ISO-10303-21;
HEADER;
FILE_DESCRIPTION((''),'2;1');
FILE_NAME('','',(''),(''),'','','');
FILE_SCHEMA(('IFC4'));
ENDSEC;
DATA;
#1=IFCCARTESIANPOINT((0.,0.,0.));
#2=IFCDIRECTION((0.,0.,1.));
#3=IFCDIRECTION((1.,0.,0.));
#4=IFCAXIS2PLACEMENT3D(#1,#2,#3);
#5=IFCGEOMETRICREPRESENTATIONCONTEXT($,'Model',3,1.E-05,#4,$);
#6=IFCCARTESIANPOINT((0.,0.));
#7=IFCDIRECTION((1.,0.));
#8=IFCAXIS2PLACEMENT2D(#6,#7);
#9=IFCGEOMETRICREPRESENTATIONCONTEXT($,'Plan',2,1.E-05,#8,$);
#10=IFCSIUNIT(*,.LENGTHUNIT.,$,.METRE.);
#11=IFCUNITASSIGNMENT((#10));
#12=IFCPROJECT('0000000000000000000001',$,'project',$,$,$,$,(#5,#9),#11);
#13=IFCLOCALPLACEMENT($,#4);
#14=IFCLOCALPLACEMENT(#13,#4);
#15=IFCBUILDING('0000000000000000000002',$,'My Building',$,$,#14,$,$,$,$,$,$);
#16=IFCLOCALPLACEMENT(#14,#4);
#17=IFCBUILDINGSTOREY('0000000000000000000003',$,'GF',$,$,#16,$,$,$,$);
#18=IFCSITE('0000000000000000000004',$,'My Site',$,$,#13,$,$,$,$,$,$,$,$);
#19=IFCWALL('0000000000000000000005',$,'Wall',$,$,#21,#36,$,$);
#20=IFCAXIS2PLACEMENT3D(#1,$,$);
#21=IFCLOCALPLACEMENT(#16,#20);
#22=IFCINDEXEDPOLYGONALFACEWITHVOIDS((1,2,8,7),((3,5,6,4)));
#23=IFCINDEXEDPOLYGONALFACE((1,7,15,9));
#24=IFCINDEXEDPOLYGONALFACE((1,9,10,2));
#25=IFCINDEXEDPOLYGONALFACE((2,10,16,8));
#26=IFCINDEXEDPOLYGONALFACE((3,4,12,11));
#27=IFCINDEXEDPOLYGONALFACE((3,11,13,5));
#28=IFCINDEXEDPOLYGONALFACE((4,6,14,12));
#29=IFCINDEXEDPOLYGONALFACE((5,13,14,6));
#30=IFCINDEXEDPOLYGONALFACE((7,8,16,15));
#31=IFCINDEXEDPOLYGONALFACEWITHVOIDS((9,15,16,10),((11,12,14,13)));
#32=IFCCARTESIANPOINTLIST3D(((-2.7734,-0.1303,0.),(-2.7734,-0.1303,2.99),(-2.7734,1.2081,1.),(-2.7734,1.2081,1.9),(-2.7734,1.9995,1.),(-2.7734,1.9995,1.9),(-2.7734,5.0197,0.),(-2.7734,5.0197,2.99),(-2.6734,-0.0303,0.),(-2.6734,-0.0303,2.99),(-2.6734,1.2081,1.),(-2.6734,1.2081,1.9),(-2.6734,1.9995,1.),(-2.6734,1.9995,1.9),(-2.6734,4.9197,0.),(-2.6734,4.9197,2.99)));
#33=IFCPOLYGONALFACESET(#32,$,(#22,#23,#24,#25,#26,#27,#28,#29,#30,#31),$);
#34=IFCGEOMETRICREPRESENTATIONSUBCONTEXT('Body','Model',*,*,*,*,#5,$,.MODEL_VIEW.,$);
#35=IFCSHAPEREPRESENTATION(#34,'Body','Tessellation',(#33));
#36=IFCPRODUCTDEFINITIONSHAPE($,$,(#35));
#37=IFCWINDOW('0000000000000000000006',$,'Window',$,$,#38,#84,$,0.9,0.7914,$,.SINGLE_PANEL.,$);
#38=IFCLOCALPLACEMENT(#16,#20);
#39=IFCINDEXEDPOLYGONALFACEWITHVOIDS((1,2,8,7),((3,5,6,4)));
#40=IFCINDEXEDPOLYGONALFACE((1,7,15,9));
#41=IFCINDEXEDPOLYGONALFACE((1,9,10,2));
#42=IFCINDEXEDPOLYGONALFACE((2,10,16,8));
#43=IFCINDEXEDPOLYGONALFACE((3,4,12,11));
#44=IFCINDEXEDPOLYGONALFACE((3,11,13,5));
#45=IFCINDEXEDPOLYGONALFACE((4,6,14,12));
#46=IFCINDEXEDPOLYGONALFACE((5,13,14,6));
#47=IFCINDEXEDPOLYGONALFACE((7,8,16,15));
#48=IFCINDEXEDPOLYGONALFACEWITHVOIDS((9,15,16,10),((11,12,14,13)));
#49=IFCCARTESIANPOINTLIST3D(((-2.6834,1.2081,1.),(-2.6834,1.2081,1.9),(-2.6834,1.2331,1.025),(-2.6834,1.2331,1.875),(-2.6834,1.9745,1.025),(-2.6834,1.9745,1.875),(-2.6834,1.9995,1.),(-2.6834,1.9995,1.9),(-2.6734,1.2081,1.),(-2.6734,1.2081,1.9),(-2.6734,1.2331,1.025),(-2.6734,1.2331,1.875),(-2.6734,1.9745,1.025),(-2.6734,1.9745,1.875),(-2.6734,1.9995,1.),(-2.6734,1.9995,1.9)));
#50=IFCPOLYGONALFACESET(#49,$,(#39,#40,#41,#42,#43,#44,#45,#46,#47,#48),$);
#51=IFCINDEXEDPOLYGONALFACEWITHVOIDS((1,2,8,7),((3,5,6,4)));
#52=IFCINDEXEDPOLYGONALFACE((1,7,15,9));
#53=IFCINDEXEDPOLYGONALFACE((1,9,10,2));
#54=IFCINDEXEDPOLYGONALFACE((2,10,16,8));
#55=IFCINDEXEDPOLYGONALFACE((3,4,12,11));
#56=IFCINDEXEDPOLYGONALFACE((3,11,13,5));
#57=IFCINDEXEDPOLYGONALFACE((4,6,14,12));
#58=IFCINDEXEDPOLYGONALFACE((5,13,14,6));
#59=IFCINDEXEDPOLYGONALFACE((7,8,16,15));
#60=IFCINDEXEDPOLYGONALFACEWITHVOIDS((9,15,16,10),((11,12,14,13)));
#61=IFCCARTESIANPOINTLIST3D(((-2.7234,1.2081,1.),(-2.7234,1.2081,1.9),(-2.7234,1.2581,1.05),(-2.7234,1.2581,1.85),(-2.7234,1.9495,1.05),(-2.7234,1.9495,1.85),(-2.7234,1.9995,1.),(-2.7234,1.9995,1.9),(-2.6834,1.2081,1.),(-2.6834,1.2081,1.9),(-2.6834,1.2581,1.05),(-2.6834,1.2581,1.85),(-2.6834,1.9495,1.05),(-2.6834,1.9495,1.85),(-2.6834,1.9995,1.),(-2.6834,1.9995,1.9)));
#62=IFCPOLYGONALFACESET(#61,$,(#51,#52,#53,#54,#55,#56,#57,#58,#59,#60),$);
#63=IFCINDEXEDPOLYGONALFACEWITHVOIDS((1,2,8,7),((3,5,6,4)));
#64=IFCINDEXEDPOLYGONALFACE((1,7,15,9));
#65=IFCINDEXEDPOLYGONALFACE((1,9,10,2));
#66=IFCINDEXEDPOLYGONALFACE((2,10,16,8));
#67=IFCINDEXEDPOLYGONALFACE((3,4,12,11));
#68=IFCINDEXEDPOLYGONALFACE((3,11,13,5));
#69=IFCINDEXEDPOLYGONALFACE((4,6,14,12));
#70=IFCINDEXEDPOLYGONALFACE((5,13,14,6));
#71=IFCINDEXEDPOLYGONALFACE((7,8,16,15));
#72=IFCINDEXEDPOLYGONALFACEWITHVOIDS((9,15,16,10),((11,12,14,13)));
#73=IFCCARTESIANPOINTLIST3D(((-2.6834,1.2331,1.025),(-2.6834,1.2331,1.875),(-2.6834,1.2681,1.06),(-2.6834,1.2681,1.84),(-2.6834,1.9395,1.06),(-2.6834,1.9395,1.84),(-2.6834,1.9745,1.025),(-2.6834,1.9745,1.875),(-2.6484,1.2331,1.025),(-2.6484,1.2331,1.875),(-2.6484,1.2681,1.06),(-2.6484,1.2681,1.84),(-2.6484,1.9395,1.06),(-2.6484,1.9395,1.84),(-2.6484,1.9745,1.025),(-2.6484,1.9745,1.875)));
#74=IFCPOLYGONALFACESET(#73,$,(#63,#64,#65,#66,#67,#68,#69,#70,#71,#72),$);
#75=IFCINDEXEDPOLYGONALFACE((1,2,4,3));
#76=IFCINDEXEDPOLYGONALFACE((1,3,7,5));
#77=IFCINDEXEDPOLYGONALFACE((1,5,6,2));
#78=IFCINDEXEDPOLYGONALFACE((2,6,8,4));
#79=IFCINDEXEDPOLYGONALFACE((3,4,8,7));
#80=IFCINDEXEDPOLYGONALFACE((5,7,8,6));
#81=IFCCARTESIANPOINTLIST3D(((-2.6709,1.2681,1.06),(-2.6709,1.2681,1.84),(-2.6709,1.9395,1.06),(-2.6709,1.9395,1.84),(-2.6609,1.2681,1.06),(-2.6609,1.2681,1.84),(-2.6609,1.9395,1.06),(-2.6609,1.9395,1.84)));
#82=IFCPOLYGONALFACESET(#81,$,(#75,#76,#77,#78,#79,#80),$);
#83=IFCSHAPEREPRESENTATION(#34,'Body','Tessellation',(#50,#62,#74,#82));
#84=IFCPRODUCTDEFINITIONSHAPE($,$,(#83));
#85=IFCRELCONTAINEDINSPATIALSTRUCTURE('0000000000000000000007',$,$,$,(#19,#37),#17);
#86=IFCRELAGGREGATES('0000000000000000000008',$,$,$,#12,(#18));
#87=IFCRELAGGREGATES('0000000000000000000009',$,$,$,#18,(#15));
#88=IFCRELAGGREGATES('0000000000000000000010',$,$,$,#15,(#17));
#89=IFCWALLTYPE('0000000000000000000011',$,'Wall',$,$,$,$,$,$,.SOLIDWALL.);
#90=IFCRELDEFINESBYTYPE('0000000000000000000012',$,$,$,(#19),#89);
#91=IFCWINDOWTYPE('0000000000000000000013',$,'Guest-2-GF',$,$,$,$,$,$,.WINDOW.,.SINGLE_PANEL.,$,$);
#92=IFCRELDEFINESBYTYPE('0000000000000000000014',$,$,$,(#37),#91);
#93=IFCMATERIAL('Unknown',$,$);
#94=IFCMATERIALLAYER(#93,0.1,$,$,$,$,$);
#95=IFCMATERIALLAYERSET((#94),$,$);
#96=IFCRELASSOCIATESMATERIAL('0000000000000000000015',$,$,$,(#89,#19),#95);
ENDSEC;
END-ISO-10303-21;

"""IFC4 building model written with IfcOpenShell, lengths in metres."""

from ifc_helpers import new_model, entity, si_unit, frame, origin_with_axes, origin_2d_with_axis, place, context, subcontext, project, spatial, line, indexed_curve, outline, extrude, shape, source, transform, mapped, material, layer, layer_set, layer_usage, type_object, type_shapes, element, fill, save


model = new_model("IFC4")

# Units and contexts
model_context = context("Model", 3, precision=1e-05, world=origin_with_axes())
plan_context = context("Plan", 2, precision=1e-05, world=origin_2d_with_axis())
body_context_1 = subcontext(model_context, "Body", "Model", "MODEL_VIEW")
body_context_2 = subcontext(plan_context, "Body", "Plan", "PLAN_VIEW")
ifc_project = project(units=[si_unit("LENGTHUNIT", "METRE")], contexts=[model_context, plan_context])

# Site, building, storey
site_placement = place(None, origin_with_axes())
site = spatial("IfcSite", under=ifc_project, at=site_placement, Name="My Site")
building_placement = place(site_placement, origin_with_axes())
building = spatial("IfcBuilding", under=site, at=building_placement, Name="My Building")
storey_placement = place(building_placement, origin_with_axes())
storey = spatial("IfcBuildingStorey", under=building, at=storey_placement, Name="GF")

# Shared definitions
ifc_material_1 = material(Name="Unknown")

# Shared definitions
ifc_layer_1 = layer(ifc_material_1, 0.1)
ifc_layer_set_1 = layer_set([ifc_layer_1])
wall_type = type_object("IfcWallType", Name="Wall", PredefinedType="SOLIDWALL", material=ifc_layer_set_1)

# Wall, opening, window
ifc_layer_usage_1 = layer_usage(ifc_layer_set_1, "AXIS2", "POSITIVE", 0.0)
wall_1_placement = place(storey_placement, frame((-2.7734, 5.0197, 0.0), z_axis=(0.0, 0.0, 1.0), x_axis=(0.0, -1.0, 0.0)))
wall_1 = element("IfcWall", 1, at=wall_1_placement, inside=storey, type_object=wall_type, material=ifc_layer_usage_1, Name="Wall", context=body_context_1, shape_type="SweptSolid", body=[
    extrude(outline(indexed_curve([(0.0, 0.0), (0.1, 0.1), (5.05, 0.1), (5.15, 0.0)], segments=[line(1, 2, 3, 4, 1)])), origin_with_axes(), (0.0, 0.0, 1.0), 2.99),
])
shared_shape_1 = source(origin_with_axes(), body_context_1, "Body", "SweptSolid", [
    extrude(outline(indexed_curve([(0.0, 0.0), (0.7914, 0.0), (0.7914, 0.9), (0.0, 0.9)], segments=[line(1, 2, 3, 4, 1)])), frame((0.0, -0.6, 0.0), z_axis=(0.0, -1.0, 0.0), x_axis=(1.0, 0.0, 0.0)), (0.0, 0.0, -1.0), 1.2),
])
opening_1_placement = place(wall_1_placement, frame((3.0202, 0.0, 1.0), z_axis=(0.0, 0.0, 1.0), x_axis=(1.0, 0.0, 0.0)))
opening_1 = element("IfcOpeningElement", 2, at=opening_1_placement, cuts=wall_1, PredefinedType="OPENING", context=body_context_1, shape_type="MappedRepresentation", body=[
    mapped(shared_shape_1, transform((0.0, 0.0, 0.0), x_axis=(1.0, 0.0, 0.0), y_axis=(0.0, 1.0, 0.0), z_axis=(0.0, 0.0, 1.0), scale=1.0)),
])
window_type_1 = type_object("IfcWindowType", Name="Guest-2-GF", PartitioningType="SINGLE_PANEL", PredefinedType="WINDOW")
shared_shape_2 = source(origin_with_axes(), body_context_1, "Body", "SweptSolid", [
    extrude(outline(indexed_curve([(0.0, 0.0), (0.7914, 0.0), (0.7914, 0.9), (0.0, 0.9)], segments=[line(1, 2, 3, 4, 1)]), holes=[indexed_curve([(0.025, 0.025), (0.7664, 0.025), (0.7664, 0.875), (0.025, 0.875)], segments=[line(1, 2, 3, 4, 1)])]), frame((0.0, 0.09, 0.0), z_axis=(0.0, -1.0, 0.0), x_axis=(1.0, 0.0, 0.0)), (0.0, 0.0, -1.0), 0.01),
    extrude(outline(indexed_curve([(0.0, 0.0), (0.7914, 0.0), (0.7914, 0.9), (0.0, 0.9)], segments=[line(1, 2, 3, 4, 1)]), holes=[indexed_curve([(0.05, 0.05), (0.7414, 0.05), (0.7414, 0.85), (0.05, 0.85)], segments=[line(1, 2, 3, 4, 1)])]), frame((0.0, 0.05, 0.0), z_axis=(0.0, -1.0, 0.0), x_axis=(1.0, 0.0, 0.0)), (0.0, 0.0, -1.0), 0.04),
    extrude(outline(indexed_curve([(0.0, 0.0), (0.7414, 0.0), (0.7414, 0.85), (0.0, 0.85)], segments=[line(1, 2, 3, 4, 1)]), holes=[indexed_curve([(0.035, 0.035), (0.7064, 0.035), (0.7064, 0.815), (0.035, 0.815)], segments=[line(1, 2, 3, 4, 1)])]), frame((0.025, 0.09, 0.025), z_axis=(0.0, -1.0, 0.0), x_axis=(1.0, 0.0, 0.0)), (0.0, 0.0, -1.0), 0.035),
    extrude(outline(indexed_curve([(0.035, 0.035), (0.7064, 0.035), (0.7064, 0.815), (0.035, 0.815)], segments=[line(1, 2, 3, 4, 1)])), frame((0.025, 0.1025, 0.025), z_axis=(0.0, -1.0, 0.0), x_axis=(1.0, 0.0, 0.0)), (0.0, 0.0, -1.0), 0.01),
])
shared_shape_3 = source(origin_with_axes(), body_context_2, "Body", "Curve2D", [
    entity("IfcIndexedPolyCurve", entity("IfcCartesianPointList2D", [[0.05, 0.05], [0.7414, 0.05]])),
    entity("IfcIndexedPolyCurve", entity("IfcCartesianPointList2D", [[0.0, 0.1], [0.025, 0.1], [0.025, 0.09], [0.05, 0.09], [0.05, 0.05], [0.0, 0.05]]), [entity("IfcLineIndex", [1, 2, 3, 4, 5, 6, 1])]),
    entity("IfcIndexedPolyCurve", entity("IfcCartesianPointList2D", [[0.7914, 0.1], [0.7664, 0.1], [0.7664, 0.09], [0.7414, 0.09], [0.7414, 0.05], [0.7914, 0.05]]), [entity("IfcLineIndex", [1, 2, 3, 4, 5, 6, 1])]),
    entity("IfcIndexedPolyCurve", entity("IfcCartesianPointList2D", [[0.025, 0.09], [0.06, 0.09], [0.06, 0.125], [0.025, 0.125]]), [entity("IfcLineIndex", [1, 2, 3, 4, 1])]),
    entity("IfcIndexedPolyCurve", entity("IfcCartesianPointList2D", [[0.7664, 0.09], [0.7314, 0.09], [0.7314, 0.125], [0.7664, 0.125]]), [entity("IfcLineIndex", [1, 2, 3, 4, 1])]),
    entity("IfcIndexedPolyCurve", entity("IfcCartesianPointList2D", [[0.06, 0.09], [0.7314, 0.09]])),
    entity("IfcIndexedPolyCurve", entity("IfcCartesianPointList2D", [[0.06, 0.125], [0.7314, 0.125]])),
    entity("IfcIndexedPolyCurve", entity("IfcCartesianPointList2D", [[0.06, 0.1075], [0.7314, 0.1075]])),
])
type_shapes(window_type_1, [shared_shape_2, shared_shape_3])
window_1_placement = place(opening_1_placement, frame((0.0, 0.0, 0.0), z_axis=(0.0, 0.0, 1.0), x_axis=(1.0, 0.0, 0.0)))
window_1 = element("IfcWindow", 3, at=window_1_placement, inside=storey, type_object=window_type_1, Name="Window", OverallHeight=0.9, OverallWidth=0.7914, PartitioningType="SINGLE_PANEL", shapes=[
    shape(body_context_1, "Body", "MappedRepresentation", [mapped(shared_shape_2, transform((0.0, 0.0, 0.0), x_axis=(1.0, 0.0, 0.0), y_axis=(0.0, 1.0, 0.0), z_axis=(0.0, 0.0, 1.0), scale=1.0))]),
    shape(body_context_2, "Body", "MappedRepresentation", [mapped(shared_shape_3, transform((0.0, 0.0, 0.0), x_axis=(1.0, 0.0, 0.0), y_axis=(0.0, 1.0, 0.0), z_axis=(0.0, 0.0, 1.0), scale=1.0))]),
])
fill(opening_1, window_1)

save(model, "model.ifc")
